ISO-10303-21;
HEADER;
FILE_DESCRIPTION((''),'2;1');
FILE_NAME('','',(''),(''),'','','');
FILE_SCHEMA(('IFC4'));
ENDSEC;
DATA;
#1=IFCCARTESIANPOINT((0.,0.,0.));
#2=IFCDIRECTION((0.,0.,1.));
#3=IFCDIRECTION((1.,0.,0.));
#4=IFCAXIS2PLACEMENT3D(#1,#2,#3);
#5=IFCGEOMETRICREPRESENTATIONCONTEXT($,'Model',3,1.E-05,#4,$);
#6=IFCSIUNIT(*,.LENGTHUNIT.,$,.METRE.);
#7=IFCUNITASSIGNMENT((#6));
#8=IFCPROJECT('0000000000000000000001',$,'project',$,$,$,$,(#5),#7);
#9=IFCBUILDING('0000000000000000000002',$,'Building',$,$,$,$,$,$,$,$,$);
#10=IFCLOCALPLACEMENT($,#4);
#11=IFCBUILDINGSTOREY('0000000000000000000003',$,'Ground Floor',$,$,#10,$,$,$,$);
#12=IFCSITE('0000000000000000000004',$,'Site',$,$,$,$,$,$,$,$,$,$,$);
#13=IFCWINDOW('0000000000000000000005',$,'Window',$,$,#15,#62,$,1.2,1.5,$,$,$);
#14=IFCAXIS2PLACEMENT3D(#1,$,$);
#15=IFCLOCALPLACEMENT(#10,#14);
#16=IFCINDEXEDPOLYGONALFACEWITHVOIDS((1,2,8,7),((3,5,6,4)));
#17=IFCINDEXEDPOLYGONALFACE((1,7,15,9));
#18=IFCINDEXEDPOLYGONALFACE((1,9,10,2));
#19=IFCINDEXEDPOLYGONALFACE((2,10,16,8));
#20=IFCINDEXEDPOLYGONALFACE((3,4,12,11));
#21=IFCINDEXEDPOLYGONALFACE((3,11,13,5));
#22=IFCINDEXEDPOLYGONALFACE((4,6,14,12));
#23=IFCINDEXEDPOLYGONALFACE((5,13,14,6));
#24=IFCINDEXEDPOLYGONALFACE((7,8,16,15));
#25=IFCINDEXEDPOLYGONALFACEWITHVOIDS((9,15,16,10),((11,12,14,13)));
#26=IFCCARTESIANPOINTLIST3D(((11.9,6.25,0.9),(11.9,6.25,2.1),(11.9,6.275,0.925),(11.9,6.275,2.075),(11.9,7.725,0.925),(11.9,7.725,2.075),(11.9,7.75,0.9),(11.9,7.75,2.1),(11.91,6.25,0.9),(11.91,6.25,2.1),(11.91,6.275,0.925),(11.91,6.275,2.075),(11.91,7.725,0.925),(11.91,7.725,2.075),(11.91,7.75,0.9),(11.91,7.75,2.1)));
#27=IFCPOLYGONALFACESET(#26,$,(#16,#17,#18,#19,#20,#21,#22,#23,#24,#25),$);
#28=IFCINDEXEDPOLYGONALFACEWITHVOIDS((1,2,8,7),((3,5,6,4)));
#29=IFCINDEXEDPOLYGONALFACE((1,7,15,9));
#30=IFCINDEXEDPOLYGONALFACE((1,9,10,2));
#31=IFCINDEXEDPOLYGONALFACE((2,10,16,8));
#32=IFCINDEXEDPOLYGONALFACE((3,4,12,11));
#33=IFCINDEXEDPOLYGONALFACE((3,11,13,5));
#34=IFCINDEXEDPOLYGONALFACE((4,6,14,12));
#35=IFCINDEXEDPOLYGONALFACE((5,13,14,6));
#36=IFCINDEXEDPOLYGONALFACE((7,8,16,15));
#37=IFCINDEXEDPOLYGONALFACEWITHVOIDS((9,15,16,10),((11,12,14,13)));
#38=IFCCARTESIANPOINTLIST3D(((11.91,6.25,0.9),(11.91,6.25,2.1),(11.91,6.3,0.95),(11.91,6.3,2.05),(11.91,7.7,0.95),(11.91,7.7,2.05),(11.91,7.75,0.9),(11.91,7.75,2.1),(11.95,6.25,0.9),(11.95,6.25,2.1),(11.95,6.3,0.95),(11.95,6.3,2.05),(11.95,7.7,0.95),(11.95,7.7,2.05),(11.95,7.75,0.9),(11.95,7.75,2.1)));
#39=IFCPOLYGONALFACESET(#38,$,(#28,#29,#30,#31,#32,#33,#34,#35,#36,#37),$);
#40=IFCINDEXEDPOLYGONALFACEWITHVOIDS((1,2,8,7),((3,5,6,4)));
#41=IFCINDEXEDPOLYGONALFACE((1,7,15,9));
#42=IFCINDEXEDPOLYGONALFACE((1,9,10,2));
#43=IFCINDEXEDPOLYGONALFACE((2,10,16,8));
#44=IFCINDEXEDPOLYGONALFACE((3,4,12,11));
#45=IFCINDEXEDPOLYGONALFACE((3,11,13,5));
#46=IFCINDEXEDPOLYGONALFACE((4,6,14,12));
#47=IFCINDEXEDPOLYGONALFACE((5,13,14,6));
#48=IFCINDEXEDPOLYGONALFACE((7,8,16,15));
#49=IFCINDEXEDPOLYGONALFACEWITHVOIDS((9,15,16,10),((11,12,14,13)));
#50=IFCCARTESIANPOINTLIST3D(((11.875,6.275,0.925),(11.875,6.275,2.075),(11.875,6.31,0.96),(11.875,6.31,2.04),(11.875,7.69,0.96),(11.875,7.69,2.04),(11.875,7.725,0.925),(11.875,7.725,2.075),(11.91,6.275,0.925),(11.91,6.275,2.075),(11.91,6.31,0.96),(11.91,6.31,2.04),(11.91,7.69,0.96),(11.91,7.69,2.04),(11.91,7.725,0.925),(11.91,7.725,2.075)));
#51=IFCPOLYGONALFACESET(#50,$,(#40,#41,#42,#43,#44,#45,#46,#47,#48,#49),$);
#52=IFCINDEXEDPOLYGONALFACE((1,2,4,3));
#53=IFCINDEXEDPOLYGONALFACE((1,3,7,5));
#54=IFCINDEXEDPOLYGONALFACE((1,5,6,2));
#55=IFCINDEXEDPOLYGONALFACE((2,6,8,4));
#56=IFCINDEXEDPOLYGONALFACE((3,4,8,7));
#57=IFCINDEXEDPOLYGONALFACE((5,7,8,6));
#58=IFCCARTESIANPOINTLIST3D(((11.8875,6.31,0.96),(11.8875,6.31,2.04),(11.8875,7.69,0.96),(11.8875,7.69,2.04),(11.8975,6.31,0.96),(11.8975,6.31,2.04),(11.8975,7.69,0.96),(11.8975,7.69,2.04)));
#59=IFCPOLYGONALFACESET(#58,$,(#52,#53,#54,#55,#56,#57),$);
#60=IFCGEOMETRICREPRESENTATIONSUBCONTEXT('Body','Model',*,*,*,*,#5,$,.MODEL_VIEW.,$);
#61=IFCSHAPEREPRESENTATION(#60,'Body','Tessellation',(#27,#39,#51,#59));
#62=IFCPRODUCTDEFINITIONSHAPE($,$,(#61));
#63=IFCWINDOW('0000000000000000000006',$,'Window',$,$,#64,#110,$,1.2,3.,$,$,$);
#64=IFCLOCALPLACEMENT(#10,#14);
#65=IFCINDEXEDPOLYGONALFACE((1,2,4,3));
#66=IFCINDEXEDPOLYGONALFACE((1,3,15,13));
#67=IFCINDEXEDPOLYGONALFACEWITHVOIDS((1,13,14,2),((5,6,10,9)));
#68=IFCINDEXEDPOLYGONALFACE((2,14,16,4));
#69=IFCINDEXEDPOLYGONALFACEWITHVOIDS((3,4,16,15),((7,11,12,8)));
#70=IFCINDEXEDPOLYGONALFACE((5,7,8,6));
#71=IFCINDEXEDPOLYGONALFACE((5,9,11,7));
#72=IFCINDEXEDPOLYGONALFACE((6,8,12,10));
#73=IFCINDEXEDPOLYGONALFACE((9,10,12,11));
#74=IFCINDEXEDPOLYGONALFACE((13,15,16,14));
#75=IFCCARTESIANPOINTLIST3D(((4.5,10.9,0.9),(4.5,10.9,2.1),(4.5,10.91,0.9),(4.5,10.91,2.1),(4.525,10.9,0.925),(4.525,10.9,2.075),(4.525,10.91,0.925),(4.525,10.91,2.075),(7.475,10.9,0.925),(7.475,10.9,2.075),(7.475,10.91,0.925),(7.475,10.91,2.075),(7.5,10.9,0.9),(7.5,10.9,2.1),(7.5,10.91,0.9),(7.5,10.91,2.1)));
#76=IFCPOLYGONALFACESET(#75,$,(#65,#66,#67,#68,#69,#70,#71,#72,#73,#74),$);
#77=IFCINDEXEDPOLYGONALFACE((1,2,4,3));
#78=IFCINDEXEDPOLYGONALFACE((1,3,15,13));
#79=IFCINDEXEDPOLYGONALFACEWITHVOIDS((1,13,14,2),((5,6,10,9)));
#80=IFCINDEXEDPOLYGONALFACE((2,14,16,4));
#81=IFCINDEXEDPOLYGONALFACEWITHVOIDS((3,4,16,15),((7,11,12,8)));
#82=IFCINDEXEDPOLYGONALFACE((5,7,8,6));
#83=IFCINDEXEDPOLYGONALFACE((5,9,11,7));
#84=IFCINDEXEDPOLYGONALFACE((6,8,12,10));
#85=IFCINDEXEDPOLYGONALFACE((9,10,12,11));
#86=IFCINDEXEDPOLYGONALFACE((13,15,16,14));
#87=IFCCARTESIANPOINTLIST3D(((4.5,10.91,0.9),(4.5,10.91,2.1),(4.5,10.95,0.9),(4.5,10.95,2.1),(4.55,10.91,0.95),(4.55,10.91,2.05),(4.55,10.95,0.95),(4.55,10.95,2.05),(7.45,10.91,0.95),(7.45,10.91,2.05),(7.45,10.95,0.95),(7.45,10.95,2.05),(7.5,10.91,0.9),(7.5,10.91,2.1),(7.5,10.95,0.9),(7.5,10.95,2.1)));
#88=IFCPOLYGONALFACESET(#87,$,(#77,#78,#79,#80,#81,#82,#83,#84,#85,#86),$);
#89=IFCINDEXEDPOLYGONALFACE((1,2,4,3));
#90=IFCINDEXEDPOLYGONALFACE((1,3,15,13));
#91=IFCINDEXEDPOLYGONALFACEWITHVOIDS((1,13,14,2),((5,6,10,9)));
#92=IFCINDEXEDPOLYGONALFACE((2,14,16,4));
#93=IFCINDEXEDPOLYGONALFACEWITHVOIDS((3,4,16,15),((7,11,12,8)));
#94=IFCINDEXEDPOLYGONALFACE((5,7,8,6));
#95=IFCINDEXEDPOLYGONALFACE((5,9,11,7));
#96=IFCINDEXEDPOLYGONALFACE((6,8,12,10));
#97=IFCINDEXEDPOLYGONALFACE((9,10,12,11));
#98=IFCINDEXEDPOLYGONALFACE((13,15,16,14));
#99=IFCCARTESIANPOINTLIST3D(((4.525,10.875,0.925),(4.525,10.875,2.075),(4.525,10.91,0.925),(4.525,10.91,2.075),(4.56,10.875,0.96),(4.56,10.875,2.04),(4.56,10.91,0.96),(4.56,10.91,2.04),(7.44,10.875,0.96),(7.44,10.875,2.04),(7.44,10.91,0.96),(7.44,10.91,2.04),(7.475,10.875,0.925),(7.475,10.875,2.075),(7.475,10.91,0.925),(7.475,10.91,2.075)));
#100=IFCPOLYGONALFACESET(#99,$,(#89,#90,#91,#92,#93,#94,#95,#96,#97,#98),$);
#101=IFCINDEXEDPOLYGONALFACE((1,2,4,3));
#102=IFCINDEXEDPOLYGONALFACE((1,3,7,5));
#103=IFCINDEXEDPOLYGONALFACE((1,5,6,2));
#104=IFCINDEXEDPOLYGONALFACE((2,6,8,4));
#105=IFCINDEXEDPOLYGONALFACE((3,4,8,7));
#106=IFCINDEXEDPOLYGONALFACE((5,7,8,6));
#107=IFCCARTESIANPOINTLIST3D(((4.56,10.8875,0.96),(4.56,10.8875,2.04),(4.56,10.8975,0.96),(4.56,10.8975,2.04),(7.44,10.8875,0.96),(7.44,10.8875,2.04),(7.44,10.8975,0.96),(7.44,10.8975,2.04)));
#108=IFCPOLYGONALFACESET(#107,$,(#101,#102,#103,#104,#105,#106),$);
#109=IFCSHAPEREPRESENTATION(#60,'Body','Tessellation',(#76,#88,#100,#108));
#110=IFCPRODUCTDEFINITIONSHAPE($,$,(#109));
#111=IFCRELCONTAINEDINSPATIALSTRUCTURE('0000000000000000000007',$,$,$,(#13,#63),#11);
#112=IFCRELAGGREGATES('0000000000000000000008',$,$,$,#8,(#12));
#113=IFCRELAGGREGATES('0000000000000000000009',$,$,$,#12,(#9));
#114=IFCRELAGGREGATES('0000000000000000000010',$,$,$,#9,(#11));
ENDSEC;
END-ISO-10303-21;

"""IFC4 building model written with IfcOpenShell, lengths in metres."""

from ifc_helpers import new_model, si_unit, frame, origin_with_axes, place, context, subcontext, project, spatial, line, indexed_curve, outline, extrude, element, save


model = new_model("IFC4")

# Units and contexts
model_context = context("Model", 3, precision=1e-05, world=origin_with_axes())
body_context = subcontext(model_context, "Body", "Model", "MODEL_VIEW")
ifc_project = project(units=[si_unit("LENGTHUNIT", "METRE")], contexts=[model_context])

# Site, building, storey
site = spatial("IfcSite", under=ifc_project, Name="Site")
building = spatial("IfcBuilding", under=site, Name="Building")
storey_placement = place(None, origin_with_axes())
storey = spatial("IfcBuildingStorey", under=building, at=storey_placement, Name="Ground Floor")

# Windows
for number, where, z_axis, x_axis, name in (
    (1, (12.0, 6.25, 0.9), (0.0, 0.0, 1.0), (0.0, 1.0, 0.0), "Window"),
):
    element("IfcWindow", number, at=place(storey_placement, frame(where, z_axis=z_axis, x_axis=x_axis)), inside=storey, Name=name, OverallHeight=1.2, OverallWidth=1.5, context=body_context, shape_type="SweptSolid", body=[
        extrude(outline(indexed_curve([(0.0, 0.0), (1.5, 0.0), (1.5, 1.2), (0.0, 1.2)], segments=[line(1, 2, 3, 4, 1)]), holes=[indexed_curve([(0.025, 0.025), (1.475, 0.025), (1.475, 1.175), (0.025, 1.175)], segments=[line(1, 2, 3, 4, 1)])]), frame((0.0, 0.09, 0.0), z_axis=(0.0, -1.0, 0.0), x_axis=(1.0, 0.0, 0.0)), (0.0, 0.0, -1.0), 0.01),
        extrude(outline(indexed_curve([(0.0, 0.0), (1.5, 0.0), (1.5, 1.2), (0.0, 1.2)], segments=[line(1, 2, 3, 4, 1)]), holes=[indexed_curve([(0.05, 0.05), (1.45, 0.05), (1.45, 1.15), (0.05, 1.15)], segments=[line(1, 2, 3, 4, 1)])]), frame((0.0, 0.05, 0.0), z_axis=(0.0, -1.0, 0.0), x_axis=(1.0, 0.0, 0.0)), (0.0, 0.0, -1.0), 0.04),
        extrude(outline(indexed_curve([(0.0, 0.0), (1.45, 0.0), (1.45, 1.15), (0.0, 1.15)], segments=[line(1, 2, 3, 4, 1)]), holes=[indexed_curve([(0.035, 0.035), (1.415, 0.035), (1.415, 1.115), (0.035, 1.115)], segments=[line(1, 2, 3, 4, 1)])]), frame((0.025, 0.09, 0.025), z_axis=(0.0, -1.0, 0.0), x_axis=(1.0, 0.0, 0.0)), (0.0, 0.0, -1.0), 0.035),
        extrude(outline(indexed_curve([(0.035, 0.035), (1.415, 0.035), (1.415, 1.115), (0.035, 1.115)], segments=[line(1, 2, 3, 4, 1)])), frame((0.025, 0.1025, 0.025), z_axis=(0.0, -1.0, 0.0), x_axis=(1.0, 0.0, 0.0)), (0.0, 0.0, -1.0), 0.01),
    ])
window_1_placement = place(storey_placement, frame((7.5, 11.0, 0.9), z_axis=(0.0, 0.0, 1.0), x_axis=(-1.0, 0.0, 0.0)))
element("IfcWindow", 2, at=window_1_placement, inside=storey, Name="Window", OverallHeight=1.2, OverallWidth=3.0, context=body_context, shape_type="SweptSolid", body=[
    extrude(outline(indexed_curve([(0.0, 0.0), (3.0, 0.0), (3.0, 1.2), (0.0, 1.2)], segments=[line(1, 2, 3, 4, 1)]), holes=[indexed_curve([(0.025, 0.025), (2.975, 0.025), (2.975, 1.175), (0.025, 1.175)], segments=[line(1, 2, 3, 4, 1)])]), frame((0.0, 0.09, 0.0), z_axis=(0.0, -1.0, 0.0), x_axis=(1.0, 0.0, 0.0)), (0.0, 0.0, -1.0), 0.01),
    extrude(outline(indexed_curve([(0.0, 0.0), (3.0, 0.0), (3.0, 1.2), (0.0, 1.2)], segments=[line(1, 2, 3, 4, 1)]), holes=[indexed_curve([(0.05, 0.05), (2.95, 0.05), (2.95, 1.15), (0.05, 1.15)], segments=[line(1, 2, 3, 4, 1)])]), frame((0.0, 0.05, 0.0), z_axis=(0.0, -1.0, 0.0), x_axis=(1.0, 0.0, 0.0)), (0.0, 0.0, -1.0), 0.04),
    extrude(outline(indexed_curve([(0.0, 0.0), (2.95, 0.0), (2.95, 1.15), (0.0, 1.15)], segments=[line(1, 2, 3, 4, 1)]), holes=[indexed_curve([(0.035, 0.035), (2.915, 0.035), (2.915, 1.115), (0.035, 1.115)], segments=[line(1, 2, 3, 4, 1)])]), frame((0.025, 0.09, 0.025), z_axis=(0.0, -1.0, 0.0), x_axis=(1.0, 0.0, 0.0)), (0.0, 0.0, -1.0), 0.035),
    extrude(outline(indexed_curve([(0.035, 0.035), (2.915, 0.035), (2.915, 1.115), (0.035, 1.115)], segments=[line(1, 2, 3, 4, 1)])), frame((0.025, 0.1025, 0.025), z_axis=(0.0, -1.0, 0.0), x_axis=(1.0, 0.0, 0.0)), (0.0, 0.0, -1.0), 0.01),
])

save(model, "model.ifc")
